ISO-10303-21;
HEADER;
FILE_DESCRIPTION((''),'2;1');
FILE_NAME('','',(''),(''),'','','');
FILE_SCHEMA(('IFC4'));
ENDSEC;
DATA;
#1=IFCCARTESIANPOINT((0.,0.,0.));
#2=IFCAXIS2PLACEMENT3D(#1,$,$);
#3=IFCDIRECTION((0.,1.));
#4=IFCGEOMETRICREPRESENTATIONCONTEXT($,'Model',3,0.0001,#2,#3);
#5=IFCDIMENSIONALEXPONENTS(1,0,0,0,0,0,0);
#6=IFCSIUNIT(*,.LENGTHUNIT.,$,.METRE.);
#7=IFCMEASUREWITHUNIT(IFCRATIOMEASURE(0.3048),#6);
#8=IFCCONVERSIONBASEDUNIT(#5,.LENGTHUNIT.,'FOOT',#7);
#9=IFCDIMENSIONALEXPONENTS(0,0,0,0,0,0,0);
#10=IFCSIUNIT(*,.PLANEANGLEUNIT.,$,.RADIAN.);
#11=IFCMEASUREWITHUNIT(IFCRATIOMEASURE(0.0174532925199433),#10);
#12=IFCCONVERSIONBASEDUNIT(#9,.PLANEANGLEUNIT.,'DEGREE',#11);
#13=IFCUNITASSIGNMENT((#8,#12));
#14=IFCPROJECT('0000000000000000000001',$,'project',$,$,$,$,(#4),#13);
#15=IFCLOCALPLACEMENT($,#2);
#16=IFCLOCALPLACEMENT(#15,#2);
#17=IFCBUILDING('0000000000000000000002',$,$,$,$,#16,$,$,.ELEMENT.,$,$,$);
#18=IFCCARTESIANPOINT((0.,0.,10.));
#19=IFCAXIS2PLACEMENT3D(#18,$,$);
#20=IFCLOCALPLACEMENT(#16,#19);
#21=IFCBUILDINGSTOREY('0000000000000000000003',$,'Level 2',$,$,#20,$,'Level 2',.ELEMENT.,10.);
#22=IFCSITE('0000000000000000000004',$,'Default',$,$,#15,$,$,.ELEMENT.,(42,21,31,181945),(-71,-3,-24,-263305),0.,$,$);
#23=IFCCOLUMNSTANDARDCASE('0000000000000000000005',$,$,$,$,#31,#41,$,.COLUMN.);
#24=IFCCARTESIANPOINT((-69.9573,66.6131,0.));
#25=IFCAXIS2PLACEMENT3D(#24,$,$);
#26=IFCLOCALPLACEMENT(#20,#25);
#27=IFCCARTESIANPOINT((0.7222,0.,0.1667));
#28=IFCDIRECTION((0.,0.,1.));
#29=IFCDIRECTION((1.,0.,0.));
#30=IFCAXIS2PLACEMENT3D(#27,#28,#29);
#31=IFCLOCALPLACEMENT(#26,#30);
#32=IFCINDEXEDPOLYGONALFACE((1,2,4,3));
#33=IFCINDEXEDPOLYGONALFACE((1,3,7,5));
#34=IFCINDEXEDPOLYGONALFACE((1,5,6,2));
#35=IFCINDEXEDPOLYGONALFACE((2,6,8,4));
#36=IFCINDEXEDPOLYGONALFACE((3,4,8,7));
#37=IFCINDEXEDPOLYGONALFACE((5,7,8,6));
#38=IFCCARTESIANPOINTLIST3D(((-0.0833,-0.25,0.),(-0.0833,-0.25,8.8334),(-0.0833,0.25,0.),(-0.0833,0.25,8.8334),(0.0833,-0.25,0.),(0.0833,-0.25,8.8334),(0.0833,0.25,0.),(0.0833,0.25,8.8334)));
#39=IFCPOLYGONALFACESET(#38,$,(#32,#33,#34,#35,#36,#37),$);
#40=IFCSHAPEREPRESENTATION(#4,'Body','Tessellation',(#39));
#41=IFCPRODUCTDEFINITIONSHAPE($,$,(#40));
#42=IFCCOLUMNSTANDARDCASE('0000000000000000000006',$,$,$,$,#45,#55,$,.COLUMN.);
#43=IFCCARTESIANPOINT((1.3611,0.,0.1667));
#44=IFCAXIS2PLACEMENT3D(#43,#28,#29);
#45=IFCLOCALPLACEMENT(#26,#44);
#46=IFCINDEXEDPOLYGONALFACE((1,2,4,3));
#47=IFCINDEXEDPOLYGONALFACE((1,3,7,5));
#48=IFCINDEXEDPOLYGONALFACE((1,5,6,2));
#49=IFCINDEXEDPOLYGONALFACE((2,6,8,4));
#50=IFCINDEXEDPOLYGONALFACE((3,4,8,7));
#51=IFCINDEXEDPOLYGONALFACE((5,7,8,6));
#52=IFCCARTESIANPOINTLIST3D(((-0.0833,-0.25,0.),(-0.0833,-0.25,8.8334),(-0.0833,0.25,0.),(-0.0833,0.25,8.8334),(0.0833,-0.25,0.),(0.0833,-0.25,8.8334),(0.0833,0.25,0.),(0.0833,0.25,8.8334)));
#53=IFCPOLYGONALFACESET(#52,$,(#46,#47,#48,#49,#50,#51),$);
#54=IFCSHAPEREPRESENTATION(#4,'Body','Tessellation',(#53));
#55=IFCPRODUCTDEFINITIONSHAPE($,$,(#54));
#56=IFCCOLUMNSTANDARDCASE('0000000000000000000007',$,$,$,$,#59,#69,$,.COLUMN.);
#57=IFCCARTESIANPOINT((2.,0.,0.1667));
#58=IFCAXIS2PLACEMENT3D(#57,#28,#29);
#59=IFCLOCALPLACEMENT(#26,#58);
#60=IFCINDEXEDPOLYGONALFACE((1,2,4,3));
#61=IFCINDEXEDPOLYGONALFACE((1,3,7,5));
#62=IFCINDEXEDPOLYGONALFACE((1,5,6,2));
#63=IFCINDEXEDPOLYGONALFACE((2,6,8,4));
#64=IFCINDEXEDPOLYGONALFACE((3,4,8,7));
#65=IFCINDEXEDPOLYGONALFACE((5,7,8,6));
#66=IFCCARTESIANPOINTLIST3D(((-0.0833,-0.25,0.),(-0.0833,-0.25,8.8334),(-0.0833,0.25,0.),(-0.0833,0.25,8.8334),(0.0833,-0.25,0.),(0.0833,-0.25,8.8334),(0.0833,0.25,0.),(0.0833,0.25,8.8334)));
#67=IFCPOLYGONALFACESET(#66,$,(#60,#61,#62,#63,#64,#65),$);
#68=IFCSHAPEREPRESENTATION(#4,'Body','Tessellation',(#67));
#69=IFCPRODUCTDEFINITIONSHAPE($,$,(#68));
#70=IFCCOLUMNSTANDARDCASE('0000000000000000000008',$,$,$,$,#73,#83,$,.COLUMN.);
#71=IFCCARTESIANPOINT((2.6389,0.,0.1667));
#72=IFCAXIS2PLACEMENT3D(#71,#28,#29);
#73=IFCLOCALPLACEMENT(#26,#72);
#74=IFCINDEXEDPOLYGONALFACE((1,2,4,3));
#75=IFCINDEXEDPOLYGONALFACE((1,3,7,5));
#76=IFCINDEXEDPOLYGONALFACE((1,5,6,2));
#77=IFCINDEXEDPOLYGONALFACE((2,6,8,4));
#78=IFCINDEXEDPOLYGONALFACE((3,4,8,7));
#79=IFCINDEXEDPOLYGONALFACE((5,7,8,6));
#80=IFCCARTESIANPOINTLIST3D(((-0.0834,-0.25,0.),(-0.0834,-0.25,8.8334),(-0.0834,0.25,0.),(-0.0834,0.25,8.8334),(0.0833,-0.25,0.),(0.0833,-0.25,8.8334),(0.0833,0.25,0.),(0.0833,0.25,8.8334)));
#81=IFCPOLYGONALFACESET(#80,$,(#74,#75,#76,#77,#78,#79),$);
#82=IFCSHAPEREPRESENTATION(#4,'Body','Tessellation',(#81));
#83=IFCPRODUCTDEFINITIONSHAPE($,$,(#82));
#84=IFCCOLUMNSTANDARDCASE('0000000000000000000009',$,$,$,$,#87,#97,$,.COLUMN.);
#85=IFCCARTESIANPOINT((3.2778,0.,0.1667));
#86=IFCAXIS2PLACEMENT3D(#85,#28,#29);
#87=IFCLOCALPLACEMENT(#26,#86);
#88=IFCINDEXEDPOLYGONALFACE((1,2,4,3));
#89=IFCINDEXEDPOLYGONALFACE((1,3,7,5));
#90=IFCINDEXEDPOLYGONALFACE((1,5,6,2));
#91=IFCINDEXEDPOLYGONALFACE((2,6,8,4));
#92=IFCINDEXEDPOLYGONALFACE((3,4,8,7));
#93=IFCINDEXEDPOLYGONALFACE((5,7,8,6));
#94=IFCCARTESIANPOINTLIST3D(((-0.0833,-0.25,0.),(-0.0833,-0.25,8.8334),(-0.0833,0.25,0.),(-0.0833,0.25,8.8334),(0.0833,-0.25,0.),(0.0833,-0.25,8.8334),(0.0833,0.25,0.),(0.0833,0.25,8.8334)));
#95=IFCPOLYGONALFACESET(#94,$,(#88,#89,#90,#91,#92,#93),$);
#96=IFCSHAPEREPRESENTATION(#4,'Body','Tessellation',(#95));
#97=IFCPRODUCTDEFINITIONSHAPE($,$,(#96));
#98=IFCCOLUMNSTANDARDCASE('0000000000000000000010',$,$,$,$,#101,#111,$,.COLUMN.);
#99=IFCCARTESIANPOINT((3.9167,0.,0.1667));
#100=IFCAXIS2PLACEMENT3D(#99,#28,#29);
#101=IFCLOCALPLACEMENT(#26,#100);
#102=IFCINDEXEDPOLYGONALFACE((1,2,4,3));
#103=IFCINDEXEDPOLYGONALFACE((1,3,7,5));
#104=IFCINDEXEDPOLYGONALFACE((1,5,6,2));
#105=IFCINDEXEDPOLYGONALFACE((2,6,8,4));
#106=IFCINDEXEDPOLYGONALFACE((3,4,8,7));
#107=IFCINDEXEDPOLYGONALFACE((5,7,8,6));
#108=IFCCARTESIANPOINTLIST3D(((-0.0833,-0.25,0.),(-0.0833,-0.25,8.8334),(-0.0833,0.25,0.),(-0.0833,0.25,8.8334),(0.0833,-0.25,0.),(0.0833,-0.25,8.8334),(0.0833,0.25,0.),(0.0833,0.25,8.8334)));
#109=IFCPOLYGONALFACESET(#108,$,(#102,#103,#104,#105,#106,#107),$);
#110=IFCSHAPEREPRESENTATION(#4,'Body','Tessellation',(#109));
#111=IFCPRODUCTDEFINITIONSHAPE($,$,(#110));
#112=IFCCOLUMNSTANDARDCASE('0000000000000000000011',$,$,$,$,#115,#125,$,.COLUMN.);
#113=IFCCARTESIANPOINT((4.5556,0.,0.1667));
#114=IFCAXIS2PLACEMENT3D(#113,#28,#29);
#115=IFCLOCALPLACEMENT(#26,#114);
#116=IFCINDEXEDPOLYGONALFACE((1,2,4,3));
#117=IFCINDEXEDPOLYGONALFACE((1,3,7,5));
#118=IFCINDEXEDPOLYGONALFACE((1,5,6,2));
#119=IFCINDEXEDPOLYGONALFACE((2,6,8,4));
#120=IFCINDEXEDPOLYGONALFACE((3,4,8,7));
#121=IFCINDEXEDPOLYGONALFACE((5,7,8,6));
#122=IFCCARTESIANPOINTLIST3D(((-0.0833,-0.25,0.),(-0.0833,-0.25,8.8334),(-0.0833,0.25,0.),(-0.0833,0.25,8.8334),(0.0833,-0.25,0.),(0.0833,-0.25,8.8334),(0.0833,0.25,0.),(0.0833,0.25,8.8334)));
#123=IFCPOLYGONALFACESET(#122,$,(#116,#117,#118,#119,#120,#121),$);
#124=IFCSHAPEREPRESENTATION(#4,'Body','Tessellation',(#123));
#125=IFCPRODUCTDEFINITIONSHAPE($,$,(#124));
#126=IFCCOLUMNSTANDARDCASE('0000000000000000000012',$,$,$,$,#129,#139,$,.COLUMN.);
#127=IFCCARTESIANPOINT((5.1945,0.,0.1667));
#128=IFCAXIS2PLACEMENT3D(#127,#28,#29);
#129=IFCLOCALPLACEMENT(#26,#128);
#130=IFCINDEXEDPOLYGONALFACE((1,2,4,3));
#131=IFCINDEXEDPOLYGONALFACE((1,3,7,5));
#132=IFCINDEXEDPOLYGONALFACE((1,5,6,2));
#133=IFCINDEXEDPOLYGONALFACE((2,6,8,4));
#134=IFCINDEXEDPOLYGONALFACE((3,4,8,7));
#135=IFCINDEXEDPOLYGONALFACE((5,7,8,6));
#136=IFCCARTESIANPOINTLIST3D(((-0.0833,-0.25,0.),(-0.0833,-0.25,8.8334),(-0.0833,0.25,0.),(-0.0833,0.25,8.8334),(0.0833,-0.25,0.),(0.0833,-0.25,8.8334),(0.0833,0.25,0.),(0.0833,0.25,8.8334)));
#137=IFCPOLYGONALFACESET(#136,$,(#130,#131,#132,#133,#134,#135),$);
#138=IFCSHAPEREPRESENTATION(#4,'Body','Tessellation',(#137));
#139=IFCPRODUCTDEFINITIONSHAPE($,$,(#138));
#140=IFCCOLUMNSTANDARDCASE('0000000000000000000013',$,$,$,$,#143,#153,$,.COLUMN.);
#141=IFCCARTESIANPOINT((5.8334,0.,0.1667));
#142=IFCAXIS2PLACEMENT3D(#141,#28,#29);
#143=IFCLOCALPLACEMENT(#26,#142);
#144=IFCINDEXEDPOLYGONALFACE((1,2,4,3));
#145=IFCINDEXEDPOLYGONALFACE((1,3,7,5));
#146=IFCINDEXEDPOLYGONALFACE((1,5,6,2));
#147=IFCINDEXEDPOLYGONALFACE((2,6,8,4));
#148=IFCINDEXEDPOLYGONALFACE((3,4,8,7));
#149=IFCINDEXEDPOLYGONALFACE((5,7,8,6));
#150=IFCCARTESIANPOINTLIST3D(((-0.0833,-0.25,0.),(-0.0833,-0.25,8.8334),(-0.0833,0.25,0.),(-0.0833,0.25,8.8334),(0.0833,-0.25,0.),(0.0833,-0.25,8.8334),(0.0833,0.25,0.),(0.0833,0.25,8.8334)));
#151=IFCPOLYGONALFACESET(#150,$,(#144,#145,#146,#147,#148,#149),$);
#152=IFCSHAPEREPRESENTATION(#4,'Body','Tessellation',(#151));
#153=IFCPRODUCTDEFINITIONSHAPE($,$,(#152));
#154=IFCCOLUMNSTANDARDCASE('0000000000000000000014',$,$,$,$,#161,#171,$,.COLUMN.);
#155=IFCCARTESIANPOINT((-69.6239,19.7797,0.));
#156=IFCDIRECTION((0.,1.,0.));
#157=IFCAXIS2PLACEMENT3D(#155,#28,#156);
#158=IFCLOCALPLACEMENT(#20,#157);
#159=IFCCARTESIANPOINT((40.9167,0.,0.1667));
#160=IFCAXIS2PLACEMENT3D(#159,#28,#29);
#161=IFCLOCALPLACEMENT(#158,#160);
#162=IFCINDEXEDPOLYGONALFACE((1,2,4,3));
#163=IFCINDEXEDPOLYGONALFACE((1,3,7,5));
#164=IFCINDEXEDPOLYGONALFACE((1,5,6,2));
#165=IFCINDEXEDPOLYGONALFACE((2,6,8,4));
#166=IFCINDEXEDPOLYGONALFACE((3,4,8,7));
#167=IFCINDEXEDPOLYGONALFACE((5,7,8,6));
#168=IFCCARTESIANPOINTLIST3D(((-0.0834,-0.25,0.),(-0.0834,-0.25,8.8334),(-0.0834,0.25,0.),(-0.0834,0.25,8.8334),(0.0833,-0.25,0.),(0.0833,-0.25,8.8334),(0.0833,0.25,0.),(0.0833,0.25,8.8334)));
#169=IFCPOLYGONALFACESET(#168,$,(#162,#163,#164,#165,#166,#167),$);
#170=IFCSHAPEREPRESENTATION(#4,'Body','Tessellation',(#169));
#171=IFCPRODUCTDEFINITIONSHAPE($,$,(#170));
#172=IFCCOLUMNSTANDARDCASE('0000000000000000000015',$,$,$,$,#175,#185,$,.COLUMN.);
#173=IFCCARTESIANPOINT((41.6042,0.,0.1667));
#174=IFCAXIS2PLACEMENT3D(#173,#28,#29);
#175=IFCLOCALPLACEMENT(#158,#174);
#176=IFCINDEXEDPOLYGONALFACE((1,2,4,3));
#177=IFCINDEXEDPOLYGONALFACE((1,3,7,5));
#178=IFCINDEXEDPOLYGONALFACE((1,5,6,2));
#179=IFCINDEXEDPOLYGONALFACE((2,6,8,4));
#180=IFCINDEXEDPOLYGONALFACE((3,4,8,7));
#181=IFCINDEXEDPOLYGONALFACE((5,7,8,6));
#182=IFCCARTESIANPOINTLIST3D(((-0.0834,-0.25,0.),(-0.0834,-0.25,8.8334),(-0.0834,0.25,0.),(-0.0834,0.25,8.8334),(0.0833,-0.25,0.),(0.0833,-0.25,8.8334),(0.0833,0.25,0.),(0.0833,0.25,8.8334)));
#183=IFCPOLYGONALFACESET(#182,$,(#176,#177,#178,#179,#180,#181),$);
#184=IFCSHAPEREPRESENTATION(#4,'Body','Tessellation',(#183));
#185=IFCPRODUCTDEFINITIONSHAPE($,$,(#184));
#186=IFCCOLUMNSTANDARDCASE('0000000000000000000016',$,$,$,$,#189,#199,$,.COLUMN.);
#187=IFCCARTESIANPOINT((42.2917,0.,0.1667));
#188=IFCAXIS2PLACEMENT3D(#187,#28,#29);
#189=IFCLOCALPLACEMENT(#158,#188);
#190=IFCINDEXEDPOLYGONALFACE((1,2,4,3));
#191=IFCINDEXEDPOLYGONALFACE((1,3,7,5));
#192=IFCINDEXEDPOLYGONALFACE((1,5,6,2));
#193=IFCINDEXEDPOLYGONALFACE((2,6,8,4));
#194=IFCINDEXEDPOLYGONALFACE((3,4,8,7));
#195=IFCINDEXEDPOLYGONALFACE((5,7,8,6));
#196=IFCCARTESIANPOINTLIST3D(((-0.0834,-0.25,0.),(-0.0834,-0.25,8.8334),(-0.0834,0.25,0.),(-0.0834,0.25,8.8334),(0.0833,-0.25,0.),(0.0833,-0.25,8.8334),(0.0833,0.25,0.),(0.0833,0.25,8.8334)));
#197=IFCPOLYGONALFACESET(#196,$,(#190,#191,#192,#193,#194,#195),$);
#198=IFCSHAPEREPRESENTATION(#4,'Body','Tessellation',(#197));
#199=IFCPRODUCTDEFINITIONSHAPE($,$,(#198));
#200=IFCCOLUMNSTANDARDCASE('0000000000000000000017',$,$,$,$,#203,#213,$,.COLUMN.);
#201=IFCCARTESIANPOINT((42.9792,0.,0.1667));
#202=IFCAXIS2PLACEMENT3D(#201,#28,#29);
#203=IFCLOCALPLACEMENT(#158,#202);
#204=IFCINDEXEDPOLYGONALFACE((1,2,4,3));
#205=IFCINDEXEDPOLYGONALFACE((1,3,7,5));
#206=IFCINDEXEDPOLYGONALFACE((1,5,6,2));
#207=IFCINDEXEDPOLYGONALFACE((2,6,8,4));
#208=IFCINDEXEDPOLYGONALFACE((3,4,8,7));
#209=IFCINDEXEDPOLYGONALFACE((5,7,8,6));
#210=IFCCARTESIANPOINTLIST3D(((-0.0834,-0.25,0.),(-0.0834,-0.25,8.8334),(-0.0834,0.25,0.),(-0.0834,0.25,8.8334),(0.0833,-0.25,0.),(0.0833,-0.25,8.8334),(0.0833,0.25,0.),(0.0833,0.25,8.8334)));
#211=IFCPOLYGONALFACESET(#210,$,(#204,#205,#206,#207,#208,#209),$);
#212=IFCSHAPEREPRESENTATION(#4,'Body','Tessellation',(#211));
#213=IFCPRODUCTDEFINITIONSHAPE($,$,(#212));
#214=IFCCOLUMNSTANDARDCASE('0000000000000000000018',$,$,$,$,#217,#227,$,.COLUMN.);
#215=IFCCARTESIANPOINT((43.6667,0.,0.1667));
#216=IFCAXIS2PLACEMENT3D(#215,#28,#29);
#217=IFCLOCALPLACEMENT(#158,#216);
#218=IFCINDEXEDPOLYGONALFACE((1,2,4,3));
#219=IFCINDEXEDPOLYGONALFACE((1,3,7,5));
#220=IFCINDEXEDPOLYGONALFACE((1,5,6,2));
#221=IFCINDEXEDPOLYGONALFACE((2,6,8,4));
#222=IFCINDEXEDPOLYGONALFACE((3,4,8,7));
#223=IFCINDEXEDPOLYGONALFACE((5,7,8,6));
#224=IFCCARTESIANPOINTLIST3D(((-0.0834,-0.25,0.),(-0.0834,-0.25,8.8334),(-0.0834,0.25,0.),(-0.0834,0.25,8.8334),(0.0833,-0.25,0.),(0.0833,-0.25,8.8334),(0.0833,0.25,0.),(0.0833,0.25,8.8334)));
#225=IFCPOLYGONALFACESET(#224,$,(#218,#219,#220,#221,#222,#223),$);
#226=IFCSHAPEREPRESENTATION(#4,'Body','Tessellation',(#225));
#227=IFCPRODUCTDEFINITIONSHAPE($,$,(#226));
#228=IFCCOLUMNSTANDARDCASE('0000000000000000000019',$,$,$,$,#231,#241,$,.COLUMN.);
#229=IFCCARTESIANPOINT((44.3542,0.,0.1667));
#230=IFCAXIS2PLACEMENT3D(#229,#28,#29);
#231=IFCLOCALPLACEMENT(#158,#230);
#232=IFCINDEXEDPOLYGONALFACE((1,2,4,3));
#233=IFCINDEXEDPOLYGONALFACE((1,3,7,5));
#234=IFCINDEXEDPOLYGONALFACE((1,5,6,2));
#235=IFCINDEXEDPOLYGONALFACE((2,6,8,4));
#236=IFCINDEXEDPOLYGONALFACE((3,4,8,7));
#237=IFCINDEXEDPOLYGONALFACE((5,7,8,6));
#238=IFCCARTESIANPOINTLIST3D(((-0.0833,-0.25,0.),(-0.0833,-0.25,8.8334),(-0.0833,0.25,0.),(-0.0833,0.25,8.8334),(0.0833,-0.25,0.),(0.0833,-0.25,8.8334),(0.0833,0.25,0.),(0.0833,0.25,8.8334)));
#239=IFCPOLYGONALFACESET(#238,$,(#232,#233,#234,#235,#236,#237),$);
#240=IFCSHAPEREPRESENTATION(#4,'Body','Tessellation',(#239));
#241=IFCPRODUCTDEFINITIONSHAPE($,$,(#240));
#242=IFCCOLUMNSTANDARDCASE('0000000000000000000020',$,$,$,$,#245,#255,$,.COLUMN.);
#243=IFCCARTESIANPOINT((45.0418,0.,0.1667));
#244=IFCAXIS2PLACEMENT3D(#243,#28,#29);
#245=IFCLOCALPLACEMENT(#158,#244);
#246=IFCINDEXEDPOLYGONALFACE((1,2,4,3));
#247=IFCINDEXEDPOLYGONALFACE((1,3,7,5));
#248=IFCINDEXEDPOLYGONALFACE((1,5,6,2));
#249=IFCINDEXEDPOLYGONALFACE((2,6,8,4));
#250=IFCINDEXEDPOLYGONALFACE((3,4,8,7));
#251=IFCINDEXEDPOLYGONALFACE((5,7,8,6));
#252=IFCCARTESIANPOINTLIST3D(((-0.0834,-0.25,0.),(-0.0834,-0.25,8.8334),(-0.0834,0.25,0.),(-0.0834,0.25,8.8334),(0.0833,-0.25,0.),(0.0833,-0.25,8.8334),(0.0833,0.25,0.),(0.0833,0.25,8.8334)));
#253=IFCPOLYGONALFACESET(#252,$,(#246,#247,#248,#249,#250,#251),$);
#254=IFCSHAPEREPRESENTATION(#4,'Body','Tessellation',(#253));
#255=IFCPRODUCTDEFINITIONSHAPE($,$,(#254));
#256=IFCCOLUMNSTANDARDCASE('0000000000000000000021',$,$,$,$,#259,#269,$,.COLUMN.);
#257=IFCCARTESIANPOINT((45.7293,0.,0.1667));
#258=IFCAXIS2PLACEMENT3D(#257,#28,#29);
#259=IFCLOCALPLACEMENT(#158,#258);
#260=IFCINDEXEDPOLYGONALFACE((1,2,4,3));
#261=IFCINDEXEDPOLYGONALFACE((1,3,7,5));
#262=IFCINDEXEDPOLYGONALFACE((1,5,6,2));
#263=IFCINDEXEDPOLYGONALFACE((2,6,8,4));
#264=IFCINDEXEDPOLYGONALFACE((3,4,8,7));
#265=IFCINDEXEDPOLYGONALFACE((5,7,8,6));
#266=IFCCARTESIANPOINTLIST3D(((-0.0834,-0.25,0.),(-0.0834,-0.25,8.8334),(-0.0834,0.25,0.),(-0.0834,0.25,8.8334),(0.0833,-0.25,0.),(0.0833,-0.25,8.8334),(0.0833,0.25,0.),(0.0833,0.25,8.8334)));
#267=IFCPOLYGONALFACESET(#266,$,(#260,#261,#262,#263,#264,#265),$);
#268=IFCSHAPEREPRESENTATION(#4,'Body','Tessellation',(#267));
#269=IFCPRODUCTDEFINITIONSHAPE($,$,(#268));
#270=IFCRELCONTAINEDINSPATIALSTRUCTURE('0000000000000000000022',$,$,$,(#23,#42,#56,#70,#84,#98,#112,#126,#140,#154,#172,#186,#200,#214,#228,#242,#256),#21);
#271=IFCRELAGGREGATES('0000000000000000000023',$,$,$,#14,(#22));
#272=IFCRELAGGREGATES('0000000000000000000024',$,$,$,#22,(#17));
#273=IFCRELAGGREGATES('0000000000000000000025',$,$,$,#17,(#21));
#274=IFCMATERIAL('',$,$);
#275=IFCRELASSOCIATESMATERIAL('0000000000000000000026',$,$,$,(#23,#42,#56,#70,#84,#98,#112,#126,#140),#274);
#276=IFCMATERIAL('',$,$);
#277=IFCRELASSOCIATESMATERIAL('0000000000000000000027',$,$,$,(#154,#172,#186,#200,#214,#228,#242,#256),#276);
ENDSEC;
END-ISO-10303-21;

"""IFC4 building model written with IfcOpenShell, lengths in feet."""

from ifc_helpers import new_model, entity, si_unit, converted_unit, direction, frame, origin, place, context, project, spatial, rectangle, extrude, material, element, save


model = new_model("IFC4")

# Units and contexts
model_context = context("Model", 3, precision=0.0001, world=origin(), true_north=direction((0.0, 1.0)))
ifc_project = project(units=[converted_unit("LENGTHUNIT", "FOOT", entity("IfcRatioMeasure", 0.3048), si_unit("LENGTHUNIT", "METRE"), dimensions=[1, 0, 0, 0, 0, 0, 0]), converted_unit("PLANEANGLEUNIT", "DEGREE", entity("IfcRatioMeasure", 0.0174532925199433), si_unit("PLANEANGLEUNIT", "RADIAN"), dimensions=[0, 0, 0, 0, 0, 0, 0])], contexts=[model_context])

# Site, building, storey
site_placement = place(None, origin())
site = spatial("IfcSite", under=ifc_project, at=site_placement, Name="Default", CompositionType="ELEMENT", RefLatitude=(42, 21, 31, 181945), RefLongitude=(-71, -3, -24, -263305), RefElevation=0.0)
building_placement = place(site_placement, origin())
building = spatial("IfcBuilding", under=site, at=building_placement, CompositionType="ELEMENT")
storey_placement = place(building_placement, frame((0.0, 0.0, 10.0)))
storey = spatial("IfcBuildingStorey", under=building, at=storey_placement, Name="Level 2", LongName="Level 2", CompositionType="ELEMENT", Elevation=10.0)

# Columns
ifc_material_1 = material(Name="")
placement_1 = place(storey_placement, frame((-69.9573, 66.6131, 0.0)))
for number, where, z_axis, x_axis in (
    (1, (0.7222, 0.0, 0.1667), (0.0, 0.0, 1.0), (1.0, 0.0, 0.0)),
    (2, (1.3611, 0.0, 0.1667), (0.0, 0.0, 1.0), (1.0, 0.0, 0.0)),
    (3, (2.0, 0.0, 0.1667), (0.0, 0.0, 1.0), (1.0, 0.0, 0.0)),
    (4, (2.6389, 0.0, 0.1667), (0.0, 0.0, 1.0), (1.0, 0.0, 0.0)),
    (5, (3.2778, 0.0, 0.1667), (0.0, 0.0, 1.0), (1.0, 0.0, 0.0)),
    (6, (3.9167, 0.0, 0.1667), (0.0, 0.0, 1.0), (1.0, 0.0, 0.0)),
    (7, (4.5556, 0.0, 0.1667), (0.0, 0.0, 1.0), (1.0, 0.0, 0.0)),
    (8, (5.1945, 0.0, 0.1667), (0.0, 0.0, 1.0), (1.0, 0.0, 0.0)),
    (9, (5.8334, 0.0, 0.1667), (0.0, 0.0, 1.0), (1.0, 0.0, 0.0)),
):
    element("IfcColumnStandardCase", number, at=place(placement_1, frame(where, z_axis=z_axis, x_axis=x_axis)), inside=storey, material=ifc_material_1, PredefinedType="COLUMN", context=model_context, shape_type="SweptSolid", body=[
        extrude(rectangle(XDim=0.1667, YDim=0.5), origin(), (0.0, 0.0, 1.0), 8.8334),
    ])
ifc_material_2 = material(Name="")
placement_2 = place(storey_placement, frame((-69.6239, 19.7797, 0.0), z_axis=(0.0, 0.0, 1.0), x_axis=(0.0, 1.0, 0.0)))
for number, where, z_axis, x_axis in (
    (10, (40.9167, 0.0, 0.1667), (0.0, 0.0, 1.0), (1.0, 0.0, 0.0)),
    (11, (41.6042, 0.0, 0.1667), (0.0, 0.0, 1.0), (1.0, 0.0, 0.0)),
    (12, (42.2917, 0.0, 0.1667), (0.0, 0.0, 1.0), (1.0, 0.0, 0.0)),
    (13, (42.9792, 0.0, 0.1667), (0.0, 0.0, 1.0), (1.0, 0.0, 0.0)),
    (14, (43.6667, 0.0, 0.1667), (0.0, 0.0, 1.0), (1.0, 0.0, 0.0)),
    (15, (44.3542, 0.0, 0.1667), (0.0, 0.0, 1.0), (1.0, 0.0, 0.0)),
    (16, (45.0418, 0.0, 0.1667), (0.0, 0.0, 1.0), (1.0, 0.0, 0.0)),
    (17, (45.7293, 0.0, 0.1667), (0.0, 0.0, 1.0), (1.0, 0.0, 0.0)),
):
    element("IfcColumnStandardCase", number, at=place(placement_2, frame(where, z_axis=z_axis, x_axis=x_axis)), inside=storey, material=ifc_material_2, PredefinedType="COLUMN", context=model_context, shape_type="SweptSolid", body=[
        extrude(rectangle(XDim=0.1667, YDim=0.5), origin(), (0.0, 0.0, 1.0), 8.8334),
    ])

save(model, "model.ifc")
